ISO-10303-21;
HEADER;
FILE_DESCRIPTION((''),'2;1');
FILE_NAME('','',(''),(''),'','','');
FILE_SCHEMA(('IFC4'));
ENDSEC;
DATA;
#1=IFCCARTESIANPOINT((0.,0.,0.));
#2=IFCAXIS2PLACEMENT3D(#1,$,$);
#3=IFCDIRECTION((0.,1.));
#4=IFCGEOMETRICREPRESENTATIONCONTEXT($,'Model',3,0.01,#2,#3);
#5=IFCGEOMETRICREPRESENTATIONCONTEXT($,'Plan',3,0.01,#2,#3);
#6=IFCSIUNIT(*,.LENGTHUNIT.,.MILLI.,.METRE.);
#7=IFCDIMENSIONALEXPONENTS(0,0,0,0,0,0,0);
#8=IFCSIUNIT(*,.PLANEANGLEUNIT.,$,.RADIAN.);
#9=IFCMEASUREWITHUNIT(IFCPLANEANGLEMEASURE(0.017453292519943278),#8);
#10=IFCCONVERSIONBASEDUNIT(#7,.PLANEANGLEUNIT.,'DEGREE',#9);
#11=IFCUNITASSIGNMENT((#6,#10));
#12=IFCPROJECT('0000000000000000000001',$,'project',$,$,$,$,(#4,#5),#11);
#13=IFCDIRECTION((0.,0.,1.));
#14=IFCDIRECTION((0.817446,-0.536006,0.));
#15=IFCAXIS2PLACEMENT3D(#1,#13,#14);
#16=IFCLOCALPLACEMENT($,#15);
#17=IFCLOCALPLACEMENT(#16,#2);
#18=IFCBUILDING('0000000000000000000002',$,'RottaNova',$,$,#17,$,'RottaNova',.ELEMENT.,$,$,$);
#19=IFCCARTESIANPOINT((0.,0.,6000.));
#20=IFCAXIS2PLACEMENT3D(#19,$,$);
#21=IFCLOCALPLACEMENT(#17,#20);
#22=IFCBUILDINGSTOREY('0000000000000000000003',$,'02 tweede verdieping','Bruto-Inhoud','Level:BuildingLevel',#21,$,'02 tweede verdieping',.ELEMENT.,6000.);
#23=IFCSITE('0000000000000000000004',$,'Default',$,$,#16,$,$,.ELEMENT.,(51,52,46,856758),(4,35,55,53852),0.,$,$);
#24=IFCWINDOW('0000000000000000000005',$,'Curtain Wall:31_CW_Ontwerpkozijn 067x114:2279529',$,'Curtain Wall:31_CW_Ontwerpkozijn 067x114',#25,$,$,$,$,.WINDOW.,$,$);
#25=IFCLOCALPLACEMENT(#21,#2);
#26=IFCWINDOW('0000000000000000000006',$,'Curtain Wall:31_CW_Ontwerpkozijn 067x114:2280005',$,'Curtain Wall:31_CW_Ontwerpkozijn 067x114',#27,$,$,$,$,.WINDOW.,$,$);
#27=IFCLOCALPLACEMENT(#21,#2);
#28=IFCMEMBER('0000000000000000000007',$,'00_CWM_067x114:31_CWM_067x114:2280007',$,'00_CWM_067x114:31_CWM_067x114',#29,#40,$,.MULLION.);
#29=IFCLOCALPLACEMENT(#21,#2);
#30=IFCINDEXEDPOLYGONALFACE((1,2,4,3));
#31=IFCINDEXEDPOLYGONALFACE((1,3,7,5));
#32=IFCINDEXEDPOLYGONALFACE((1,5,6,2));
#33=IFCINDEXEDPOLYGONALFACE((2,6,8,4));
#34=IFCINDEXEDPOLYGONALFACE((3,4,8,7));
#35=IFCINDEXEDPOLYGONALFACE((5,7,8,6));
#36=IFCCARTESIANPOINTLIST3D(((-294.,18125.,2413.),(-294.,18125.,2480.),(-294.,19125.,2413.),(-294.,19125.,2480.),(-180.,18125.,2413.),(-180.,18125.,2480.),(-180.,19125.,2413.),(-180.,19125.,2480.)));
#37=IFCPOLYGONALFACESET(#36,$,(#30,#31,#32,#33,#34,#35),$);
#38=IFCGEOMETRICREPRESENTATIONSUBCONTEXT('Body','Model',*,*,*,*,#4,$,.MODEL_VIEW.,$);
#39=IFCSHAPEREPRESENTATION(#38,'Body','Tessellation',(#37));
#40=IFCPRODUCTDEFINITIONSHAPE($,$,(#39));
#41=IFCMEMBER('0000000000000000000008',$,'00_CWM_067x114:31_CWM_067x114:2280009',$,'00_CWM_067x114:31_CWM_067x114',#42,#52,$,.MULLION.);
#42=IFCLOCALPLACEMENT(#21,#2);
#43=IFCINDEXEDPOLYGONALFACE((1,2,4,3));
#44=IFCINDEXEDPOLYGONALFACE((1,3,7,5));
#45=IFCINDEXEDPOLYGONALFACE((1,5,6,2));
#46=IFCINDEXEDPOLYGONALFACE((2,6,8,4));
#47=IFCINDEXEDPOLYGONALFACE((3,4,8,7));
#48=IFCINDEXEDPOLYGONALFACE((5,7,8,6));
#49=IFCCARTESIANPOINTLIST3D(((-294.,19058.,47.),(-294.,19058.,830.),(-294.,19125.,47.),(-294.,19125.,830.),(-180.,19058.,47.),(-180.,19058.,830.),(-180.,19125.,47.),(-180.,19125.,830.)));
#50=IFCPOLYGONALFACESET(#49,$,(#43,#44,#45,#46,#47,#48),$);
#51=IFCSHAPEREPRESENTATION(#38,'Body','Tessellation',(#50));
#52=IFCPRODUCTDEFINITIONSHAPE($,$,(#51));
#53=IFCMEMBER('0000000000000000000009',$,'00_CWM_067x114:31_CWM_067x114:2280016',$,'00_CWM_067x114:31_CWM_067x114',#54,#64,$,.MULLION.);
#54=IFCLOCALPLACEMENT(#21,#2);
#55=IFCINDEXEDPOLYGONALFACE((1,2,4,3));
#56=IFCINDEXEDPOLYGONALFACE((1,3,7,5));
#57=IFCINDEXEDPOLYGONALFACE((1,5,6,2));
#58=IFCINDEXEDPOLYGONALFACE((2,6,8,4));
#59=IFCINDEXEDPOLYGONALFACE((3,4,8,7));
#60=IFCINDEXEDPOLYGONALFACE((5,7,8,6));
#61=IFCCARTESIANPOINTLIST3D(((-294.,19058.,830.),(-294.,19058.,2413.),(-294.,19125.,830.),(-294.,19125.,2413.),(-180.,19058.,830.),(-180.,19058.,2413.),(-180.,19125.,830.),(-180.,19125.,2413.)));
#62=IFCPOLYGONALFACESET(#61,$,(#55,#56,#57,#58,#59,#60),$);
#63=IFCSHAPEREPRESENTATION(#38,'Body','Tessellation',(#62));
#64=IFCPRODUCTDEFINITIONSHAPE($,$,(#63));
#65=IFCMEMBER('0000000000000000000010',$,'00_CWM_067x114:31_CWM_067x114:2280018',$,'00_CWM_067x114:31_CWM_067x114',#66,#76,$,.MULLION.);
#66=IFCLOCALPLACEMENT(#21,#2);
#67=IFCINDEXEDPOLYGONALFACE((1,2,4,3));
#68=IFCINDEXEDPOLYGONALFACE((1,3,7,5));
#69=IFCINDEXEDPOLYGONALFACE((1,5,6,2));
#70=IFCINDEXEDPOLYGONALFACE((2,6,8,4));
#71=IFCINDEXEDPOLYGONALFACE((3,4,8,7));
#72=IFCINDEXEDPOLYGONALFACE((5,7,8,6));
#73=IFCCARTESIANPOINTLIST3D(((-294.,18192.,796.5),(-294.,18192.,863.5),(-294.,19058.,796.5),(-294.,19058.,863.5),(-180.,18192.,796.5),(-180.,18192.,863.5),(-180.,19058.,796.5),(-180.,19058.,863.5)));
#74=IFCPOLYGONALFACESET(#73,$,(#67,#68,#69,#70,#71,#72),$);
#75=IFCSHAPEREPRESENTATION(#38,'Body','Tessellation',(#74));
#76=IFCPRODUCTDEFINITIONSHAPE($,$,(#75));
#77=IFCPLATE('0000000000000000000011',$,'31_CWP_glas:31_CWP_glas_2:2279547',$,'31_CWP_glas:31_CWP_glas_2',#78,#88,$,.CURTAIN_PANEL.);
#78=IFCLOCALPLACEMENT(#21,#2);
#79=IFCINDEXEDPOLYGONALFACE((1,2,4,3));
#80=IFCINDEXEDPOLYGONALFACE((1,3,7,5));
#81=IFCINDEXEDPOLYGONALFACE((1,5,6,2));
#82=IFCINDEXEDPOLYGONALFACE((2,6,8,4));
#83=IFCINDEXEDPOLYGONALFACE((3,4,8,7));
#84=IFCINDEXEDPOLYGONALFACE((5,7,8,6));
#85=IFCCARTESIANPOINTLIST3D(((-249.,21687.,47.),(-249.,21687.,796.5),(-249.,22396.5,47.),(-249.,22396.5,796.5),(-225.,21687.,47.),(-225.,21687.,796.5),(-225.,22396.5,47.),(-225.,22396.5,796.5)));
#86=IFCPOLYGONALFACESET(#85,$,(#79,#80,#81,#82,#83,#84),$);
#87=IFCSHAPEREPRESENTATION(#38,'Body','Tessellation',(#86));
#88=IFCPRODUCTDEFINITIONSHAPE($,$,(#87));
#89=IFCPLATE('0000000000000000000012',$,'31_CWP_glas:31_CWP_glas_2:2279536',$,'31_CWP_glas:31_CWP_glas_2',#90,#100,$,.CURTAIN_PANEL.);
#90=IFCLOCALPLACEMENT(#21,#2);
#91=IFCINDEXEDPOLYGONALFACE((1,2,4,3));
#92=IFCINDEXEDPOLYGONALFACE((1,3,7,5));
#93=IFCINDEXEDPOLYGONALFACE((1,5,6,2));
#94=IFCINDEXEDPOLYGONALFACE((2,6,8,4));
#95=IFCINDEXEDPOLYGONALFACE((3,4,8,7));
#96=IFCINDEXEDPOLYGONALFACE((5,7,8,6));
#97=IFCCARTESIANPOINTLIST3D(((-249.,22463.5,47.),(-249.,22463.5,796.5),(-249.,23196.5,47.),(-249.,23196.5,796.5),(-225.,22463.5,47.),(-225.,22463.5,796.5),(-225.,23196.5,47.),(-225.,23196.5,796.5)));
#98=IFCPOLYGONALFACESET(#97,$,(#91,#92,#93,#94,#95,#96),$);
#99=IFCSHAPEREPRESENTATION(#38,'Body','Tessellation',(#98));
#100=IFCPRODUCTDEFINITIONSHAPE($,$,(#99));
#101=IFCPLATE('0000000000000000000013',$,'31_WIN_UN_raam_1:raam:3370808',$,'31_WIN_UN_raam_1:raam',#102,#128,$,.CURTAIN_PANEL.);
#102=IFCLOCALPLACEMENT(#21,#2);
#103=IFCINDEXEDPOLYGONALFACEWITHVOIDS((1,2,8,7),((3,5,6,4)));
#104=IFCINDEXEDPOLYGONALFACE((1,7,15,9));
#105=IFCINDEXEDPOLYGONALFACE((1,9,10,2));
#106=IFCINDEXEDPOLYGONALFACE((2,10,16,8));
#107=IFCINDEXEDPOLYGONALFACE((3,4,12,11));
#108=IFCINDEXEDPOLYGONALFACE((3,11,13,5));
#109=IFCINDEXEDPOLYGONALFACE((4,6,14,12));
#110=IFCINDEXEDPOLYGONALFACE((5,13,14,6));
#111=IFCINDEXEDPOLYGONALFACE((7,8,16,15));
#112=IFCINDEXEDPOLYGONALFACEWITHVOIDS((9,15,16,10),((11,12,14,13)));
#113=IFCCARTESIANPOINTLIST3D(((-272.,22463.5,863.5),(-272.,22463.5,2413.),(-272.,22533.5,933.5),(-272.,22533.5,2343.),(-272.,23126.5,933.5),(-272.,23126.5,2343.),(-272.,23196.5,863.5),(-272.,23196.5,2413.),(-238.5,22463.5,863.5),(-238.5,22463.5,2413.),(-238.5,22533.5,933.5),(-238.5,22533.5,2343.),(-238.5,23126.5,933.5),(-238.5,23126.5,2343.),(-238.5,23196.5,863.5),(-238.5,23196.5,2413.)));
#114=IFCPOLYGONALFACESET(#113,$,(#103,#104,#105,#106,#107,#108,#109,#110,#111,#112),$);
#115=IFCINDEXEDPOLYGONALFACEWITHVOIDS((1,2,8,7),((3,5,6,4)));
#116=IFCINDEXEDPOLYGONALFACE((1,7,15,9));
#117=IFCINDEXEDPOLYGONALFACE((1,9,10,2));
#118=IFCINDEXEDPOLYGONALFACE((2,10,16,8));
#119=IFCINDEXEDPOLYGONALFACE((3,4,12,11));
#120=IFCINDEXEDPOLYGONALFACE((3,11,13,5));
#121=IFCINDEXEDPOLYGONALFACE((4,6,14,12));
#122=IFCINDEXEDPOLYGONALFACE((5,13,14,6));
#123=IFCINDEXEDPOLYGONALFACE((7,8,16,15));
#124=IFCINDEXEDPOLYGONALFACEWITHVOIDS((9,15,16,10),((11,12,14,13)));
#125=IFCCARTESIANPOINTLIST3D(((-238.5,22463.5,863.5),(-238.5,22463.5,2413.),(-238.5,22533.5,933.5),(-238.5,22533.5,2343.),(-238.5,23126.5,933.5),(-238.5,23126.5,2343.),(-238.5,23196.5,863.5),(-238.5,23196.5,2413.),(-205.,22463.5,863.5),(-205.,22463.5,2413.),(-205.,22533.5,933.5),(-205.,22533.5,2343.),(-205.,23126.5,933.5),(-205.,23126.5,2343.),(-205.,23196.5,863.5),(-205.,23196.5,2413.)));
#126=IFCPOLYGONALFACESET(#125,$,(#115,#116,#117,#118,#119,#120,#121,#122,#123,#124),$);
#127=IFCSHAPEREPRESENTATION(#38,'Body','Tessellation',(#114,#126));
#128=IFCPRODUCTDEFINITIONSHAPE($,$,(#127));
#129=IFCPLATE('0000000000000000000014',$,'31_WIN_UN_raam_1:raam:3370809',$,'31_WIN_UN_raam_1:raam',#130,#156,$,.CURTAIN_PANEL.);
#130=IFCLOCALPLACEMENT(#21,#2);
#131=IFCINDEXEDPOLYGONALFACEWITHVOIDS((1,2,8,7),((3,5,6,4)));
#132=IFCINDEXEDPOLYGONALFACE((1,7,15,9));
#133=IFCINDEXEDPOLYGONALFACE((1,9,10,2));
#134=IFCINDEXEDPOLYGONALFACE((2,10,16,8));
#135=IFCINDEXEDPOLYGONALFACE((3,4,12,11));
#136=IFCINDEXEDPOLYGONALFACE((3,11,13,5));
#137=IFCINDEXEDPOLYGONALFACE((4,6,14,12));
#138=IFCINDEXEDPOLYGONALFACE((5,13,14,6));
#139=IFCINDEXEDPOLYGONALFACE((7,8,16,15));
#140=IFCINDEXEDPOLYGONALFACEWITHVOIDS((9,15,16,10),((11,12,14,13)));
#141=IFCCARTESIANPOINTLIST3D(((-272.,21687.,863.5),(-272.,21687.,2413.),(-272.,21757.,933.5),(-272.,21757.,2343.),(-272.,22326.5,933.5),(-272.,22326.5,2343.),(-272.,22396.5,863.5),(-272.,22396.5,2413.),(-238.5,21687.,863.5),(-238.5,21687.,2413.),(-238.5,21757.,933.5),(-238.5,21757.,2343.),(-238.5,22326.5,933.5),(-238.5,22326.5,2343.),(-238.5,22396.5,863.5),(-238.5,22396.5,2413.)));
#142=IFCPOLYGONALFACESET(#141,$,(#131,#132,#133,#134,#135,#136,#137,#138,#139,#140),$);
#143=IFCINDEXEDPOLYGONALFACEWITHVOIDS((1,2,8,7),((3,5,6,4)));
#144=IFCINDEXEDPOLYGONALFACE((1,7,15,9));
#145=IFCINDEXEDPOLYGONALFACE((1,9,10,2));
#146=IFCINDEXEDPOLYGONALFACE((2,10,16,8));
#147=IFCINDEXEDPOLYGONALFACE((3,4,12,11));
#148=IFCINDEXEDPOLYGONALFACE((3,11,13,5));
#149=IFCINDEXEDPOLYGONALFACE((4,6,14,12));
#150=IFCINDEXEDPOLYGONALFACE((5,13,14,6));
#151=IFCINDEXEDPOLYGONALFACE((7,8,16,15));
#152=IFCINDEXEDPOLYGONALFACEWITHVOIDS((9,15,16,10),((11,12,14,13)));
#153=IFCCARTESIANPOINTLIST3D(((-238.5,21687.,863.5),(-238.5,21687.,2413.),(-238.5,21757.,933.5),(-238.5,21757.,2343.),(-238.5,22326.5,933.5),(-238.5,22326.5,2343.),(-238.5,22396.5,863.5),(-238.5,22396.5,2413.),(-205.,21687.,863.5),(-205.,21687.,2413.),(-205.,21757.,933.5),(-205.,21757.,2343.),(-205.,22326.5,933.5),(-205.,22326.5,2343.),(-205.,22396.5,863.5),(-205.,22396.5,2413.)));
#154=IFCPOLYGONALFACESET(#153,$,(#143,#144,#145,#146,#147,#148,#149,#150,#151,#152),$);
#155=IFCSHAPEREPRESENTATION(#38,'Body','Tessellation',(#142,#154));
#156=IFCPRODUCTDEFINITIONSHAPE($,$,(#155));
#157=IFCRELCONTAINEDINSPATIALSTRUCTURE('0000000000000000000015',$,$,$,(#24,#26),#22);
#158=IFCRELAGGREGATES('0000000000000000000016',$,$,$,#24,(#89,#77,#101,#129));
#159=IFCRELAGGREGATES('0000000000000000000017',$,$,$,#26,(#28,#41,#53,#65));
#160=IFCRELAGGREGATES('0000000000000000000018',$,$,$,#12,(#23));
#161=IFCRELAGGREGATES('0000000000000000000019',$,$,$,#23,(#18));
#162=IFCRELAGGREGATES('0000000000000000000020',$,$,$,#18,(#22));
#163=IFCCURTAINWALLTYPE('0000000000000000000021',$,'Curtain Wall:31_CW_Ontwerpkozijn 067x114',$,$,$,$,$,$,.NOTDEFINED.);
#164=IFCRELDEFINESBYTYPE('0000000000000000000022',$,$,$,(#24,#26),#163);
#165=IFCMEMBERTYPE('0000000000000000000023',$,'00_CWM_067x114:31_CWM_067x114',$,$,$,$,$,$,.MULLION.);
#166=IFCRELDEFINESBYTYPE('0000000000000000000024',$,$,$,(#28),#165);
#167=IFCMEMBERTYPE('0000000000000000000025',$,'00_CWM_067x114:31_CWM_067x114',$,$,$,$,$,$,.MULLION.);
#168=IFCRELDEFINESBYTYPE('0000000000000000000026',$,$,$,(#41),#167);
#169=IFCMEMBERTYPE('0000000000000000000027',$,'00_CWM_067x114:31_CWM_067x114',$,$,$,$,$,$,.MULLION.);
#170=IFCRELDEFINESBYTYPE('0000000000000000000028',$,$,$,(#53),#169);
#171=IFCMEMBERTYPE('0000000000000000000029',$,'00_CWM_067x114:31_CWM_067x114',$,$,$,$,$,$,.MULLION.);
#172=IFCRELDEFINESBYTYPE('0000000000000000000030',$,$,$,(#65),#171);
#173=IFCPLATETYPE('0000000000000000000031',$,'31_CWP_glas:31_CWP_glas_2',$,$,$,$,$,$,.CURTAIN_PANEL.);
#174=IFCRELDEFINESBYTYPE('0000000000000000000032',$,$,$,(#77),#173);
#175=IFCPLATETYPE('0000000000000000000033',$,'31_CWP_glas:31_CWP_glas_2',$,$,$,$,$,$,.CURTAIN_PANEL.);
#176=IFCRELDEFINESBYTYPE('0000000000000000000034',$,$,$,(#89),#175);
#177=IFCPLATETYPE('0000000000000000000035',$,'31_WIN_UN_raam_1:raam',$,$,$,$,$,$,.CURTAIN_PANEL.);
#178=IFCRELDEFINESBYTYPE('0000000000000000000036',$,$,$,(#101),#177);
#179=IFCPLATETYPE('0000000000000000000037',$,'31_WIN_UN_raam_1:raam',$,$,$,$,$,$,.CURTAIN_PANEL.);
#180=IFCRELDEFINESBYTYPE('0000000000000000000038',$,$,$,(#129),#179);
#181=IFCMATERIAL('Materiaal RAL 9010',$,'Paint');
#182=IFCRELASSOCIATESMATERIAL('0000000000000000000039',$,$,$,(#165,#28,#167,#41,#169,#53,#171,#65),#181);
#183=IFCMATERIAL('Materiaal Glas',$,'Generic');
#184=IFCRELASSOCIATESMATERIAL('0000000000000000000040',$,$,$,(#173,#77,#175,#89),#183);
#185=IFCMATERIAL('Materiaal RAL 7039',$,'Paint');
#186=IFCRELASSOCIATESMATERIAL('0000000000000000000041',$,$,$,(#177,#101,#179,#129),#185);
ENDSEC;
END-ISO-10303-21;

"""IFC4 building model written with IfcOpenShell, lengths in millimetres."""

from ifc_helpers import new_model, entity, si_unit, converted_unit, direction, frame, origin, place, context, subcontext, project, spatial, indexed_curve, outline, extrude, source, transform, mapped, material, type_object, type_shapes, element, aggregate, save


model = new_model("IFC4")

# Units and contexts
model_context = context("Model", 3, precision=0.01, world=origin(), true_north=direction((0.0, 1.0)))
plan_context = context("Plan", 3, precision=0.01, world=origin(), true_north=direction((0.0, 1.0)))
body_context = subcontext(model_context, "Body", "Model", "MODEL_VIEW")
ifc_project = project(units=[si_unit("LENGTHUNIT", "METRE", prefix="MILLI"), converted_unit("PLANEANGLEUNIT", "DEGREE", entity("IfcPlaneAngleMeasure", 0.017453292519943278), si_unit("PLANEANGLEUNIT", "RADIAN"), dimensions=[0, 0, 0, 0, 0, 0, 0])], contexts=[model_context, plan_context])

# Site, building, storey
site_placement = place(None, frame((0.0, 0.0, 0.0), z_axis=(0.0, 0.0, 1.0), x_axis=(0.817446, -0.536006, 0.0)))
site = spatial("IfcSite", under=ifc_project, at=site_placement, Name="Default", CompositionType="ELEMENT", RefLatitude=(51, 52, 46, 856758), RefLongitude=(4, 35, 55, 53852), RefElevation=0.0)
building_placement = place(site_placement, origin())
building = spatial("IfcBuilding", under=site, at=building_placement, Name="RottaNova", LongName="RottaNova", CompositionType="ELEMENT")
storey_placement = place(building_placement, frame((0.0, 0.0, 6000.0)))
storey = spatial("IfcBuildingStorey", under=building, at=storey_placement, Name="02 tweede verdieping", Description="Bruto-Inhoud", ObjectType="Level:BuildingLevel", LongName="02 tweede verdieping", CompositionType="ELEMENT", Elevation=6000.0)

# Windows, members
curtain_wall_type = type_object("IfcCurtainWallType", Name="Curtain Wall:31_CW_Ontwerpkozijn 067x114", PredefinedType="NOTDEFINED")
window_1_placement = place(storey_placement, frame((0.0, 0.0, -6000.0)))
window_1 = element("IfcWindow", 1, at=window_1_placement, inside=storey, type_object=curtain_wall_type, Name="Curtain Wall:31_CW_Ontwerpkozijn 067x114:2279529", ObjectType="Curtain Wall:31_CW_Ontwerpkozijn 067x114", PredefinedType="WINDOW")
ifc_material_1 = material(Name="Materiaal RAL 9010", Category="Paint")
window_2_placement = place(storey_placement, frame((0.0, 0.0, -6000.0)))
window_2 = element("IfcWindow", 2, at=window_2_placement, inside=storey, type_object=curtain_wall_type, Name="Curtain Wall:31_CW_Ontwerpkozijn 067x114:2280005", ObjectType="Curtain Wall:31_CW_Ontwerpkozijn 067x114", PredefinedType="WINDOW")
member_type_1 = type_object("IfcMemberType", Name="00_CWM_067x114:31_CWM_067x114", PredefinedType="MULLION", material=ifc_material_1)
shared_shape_1 = source(origin(), body_context, "Body", "SweptSolid", [
    extrude(outline(indexed_curve([(-33.5, -57.0), (33.5, -57.0), (33.5, 57.0), (-33.5, 57.0), (-33.5, -57.0)], self_intersect=False)), frame((-33.5, -57.0, -1000.0), z_axis=(0.0, 0.0, 1.0), x_axis=(-1.0, 0.0, 0.0)), (0.0, 0.0, 1.0), 1000.0),
])
type_shapes(member_type_1, [shared_shape_1])
member_1_placement = place(window_2_placement, frame((-180.0, 19125.0, 8480.0), z_axis=(0.0, 1.0, 0.0), x_axis=(0.0, 0.0, 1.0)))
member_1 = element("IfcMember", 3, at=member_1_placement, type_object=member_type_1, material=ifc_material_1, Name="00_CWM_067x114:31_CWM_067x114:2280007", ObjectType="00_CWM_067x114:31_CWM_067x114", PredefinedType="MULLION", context=body_context, shape_type="MappedRepresentation", body=[
    mapped(shared_shape_1, transform((0.0, 0.0, 0.0), scale=1.0)),
])
member_type_2 = type_object("IfcMemberType", Name="00_CWM_067x114:31_CWM_067x114", PredefinedType="MULLION", material=ifc_material_1)
shared_shape_2 = source(origin(), body_context, "Body", "SweptSolid", [
    extrude(outline(indexed_curve([(-33.5, -57.0), (33.5, -57.0), (33.5, 57.0), (-33.5, 57.0), (-33.5, -57.0)], self_intersect=False)), frame((-33.5, -57.0, -783.0), z_axis=(0.0, 0.0, 1.0), x_axis=(-1.0, 0.0, 0.0)), (0.0, 0.0, 1.0), 783.0),
])
type_shapes(member_type_2, [shared_shape_2])
member_2_placement = place(window_2_placement, frame((-180.0, 19125.0, 6047.0), z_axis=(0.0, 0.0, -1.0), x_axis=(0.0, 1.0, 0.0)))
member_2 = element("IfcMember", 4, at=member_2_placement, type_object=member_type_2, material=ifc_material_1, Name="00_CWM_067x114:31_CWM_067x114:2280009", ObjectType="00_CWM_067x114:31_CWM_067x114", PredefinedType="MULLION", context=body_context, shape_type="MappedRepresentation", body=[
    mapped(shared_shape_2, transform((0.0, 0.0, 0.0), scale=1.0)),
])
member_type_3 = type_object("IfcMemberType", Name="00_CWM_067x114:31_CWM_067x114", PredefinedType="MULLION", material=ifc_material_1)
shared_shape_3 = source(origin(), body_context, "Body", "SweptSolid", [
    extrude(outline(indexed_curve([(-33.5, -57.0), (33.5, -57.0), (33.5, 57.0), (-33.5, 57.0), (-33.5, -57.0)], self_intersect=False)), frame((-33.5, -57.0, -1583.0), z_axis=(0.0, 0.0, 1.0), x_axis=(-1.0, 0.0, 0.0)), (0.0, 0.0, 1.0), 1583.0),
])
type_shapes(member_type_3, [shared_shape_3])
member_3_placement = place(window_2_placement, frame((-180.0, 19125.0, 6830.0), z_axis=(0.0, 0.0, -1.0), x_axis=(0.0, 1.0, 0.0)))
member_3 = element("IfcMember", 5, at=member_3_placement, type_object=member_type_3, material=ifc_material_1, Name="00_CWM_067x114:31_CWM_067x114:2280016", ObjectType="00_CWM_067x114:31_CWM_067x114", PredefinedType="MULLION", context=body_context, shape_type="MappedRepresentation", body=[
    mapped(shared_shape_3, transform((0.0, 0.0, 0.0), scale=1.0)),
])
member_type_4 = type_object("IfcMemberType", Name="00_CWM_067x114:31_CWM_067x114", PredefinedType="MULLION", material=ifc_material_1)
shared_shape_4 = source(origin(), body_context, "Body", "SweptSolid", [
    extrude(outline(indexed_curve([(-33.5, -57.0), (33.5, -57.0), (33.5, 57.0), (-33.5, 57.0), (-33.5, -57.0)], self_intersect=False)), frame((0.0, -57.0, -866.0), z_axis=(0.0, 0.0, 1.0), x_axis=(-1.0, 0.0, 0.0)), (0.0, 0.0, 1.0), 866.0),
])
type_shapes(member_type_4, [shared_shape_4])
member_4_placement = place(window_2_placement, frame((-180.0, 19058.0, 6830.0), z_axis=(0.0, 1.0, 0.0), x_axis=(0.0, 0.0, 1.0)))
member_4 = element("IfcMember", 6, at=member_4_placement, type_object=member_type_4, material=ifc_material_1, Name="00_CWM_067x114:31_CWM_067x114:2280018", ObjectType="00_CWM_067x114:31_CWM_067x114", PredefinedType="MULLION", context=body_context, shape_type="MappedRepresentation", body=[
    mapped(shared_shape_4, transform((0.0, 0.0, 0.0), scale=1.0)),
])

# Plates
ifc_material_2 = material(Name="Materiaal Glas", Category="Generic")
plate_type_1 = type_object("IfcPlateType", Name="31_CWP_glas:31_CWP_glas_2", PredefinedType="CURTAIN_PANEL", material=ifc_material_2)
shared_shape_5 = source(origin(), body_context, "Body", "SweptSolid", [
    extrude(outline(indexed_curve([(-12.0, -354.8), (12.0, -354.8), (12.0, 354.8), (-12.0, 354.8), (-12.0, -354.8)], self_intersect=False)), frame((0.0, -57.0, 0.0), z_axis=(0.0, 0.0, 1.0), x_axis=(0.0, 1.0, 0.0)), (0.0, 0.0, 1.0), 749.5),
])
type_shapes(plate_type_1, [shared_shape_5])
plate_1_placement = place(window_1_placement, frame((-180.0, 22041.7, 6047.0), z_axis=(0.0, 0.0, 1.0), x_axis=(0.0, -1.0, 0.0)))
plate_1 = element("IfcPlate", 7, at=plate_1_placement, type_object=plate_type_1, material=ifc_material_2, Name="31_CWP_glas:31_CWP_glas_2:2279547", ObjectType="31_CWP_glas:31_CWP_glas_2", PredefinedType="CURTAIN_PANEL", context=body_context, shape_type="MappedRepresentation", body=[
    mapped(shared_shape_5, transform((0.0, 0.0, 0.0), scale=1.0)),
])
plate_type_2 = type_object("IfcPlateType", Name="31_CWP_glas:31_CWP_glas_2", PredefinedType="CURTAIN_PANEL", material=ifc_material_2)
shared_shape_6 = source(origin(), body_context, "Body", "SweptSolid", [
    extrude(outline(indexed_curve([(-12.0, -366.5), (12.0, -366.5), (12.0, 366.5), (-12.0, 366.5), (-12.0, -366.5)], self_intersect=False)), frame((0.0, -57.0, 0.0), z_axis=(0.0, 0.0, 1.0), x_axis=(0.0, 1.0, 0.0)), (0.0, 0.0, 1.0), 749.5),
])
type_shapes(plate_type_2, [shared_shape_6])
plate_2_placement = place(window_1_placement, frame((-180.0, 22830.0, 6047.0), z_axis=(0.0, 0.0, 1.0), x_axis=(0.0, -1.0, 0.0)))
plate_2 = element("IfcPlate", 8, at=plate_2_placement, type_object=plate_type_2, material=ifc_material_2, Name="31_CWP_glas:31_CWP_glas_2:2279536", ObjectType="31_CWP_glas:31_CWP_glas_2", PredefinedType="CURTAIN_PANEL", context=body_context, shape_type="MappedRepresentation", body=[
    mapped(shared_shape_6, transform((0.0, 0.0, 0.0), scale=1.0)),
])
ifc_material_3 = material(Name="Materiaal RAL 7039", Category="Paint")
plate_type_3 = type_object("IfcPlateType", Name="31_WIN_UN_raam_1:raam", PredefinedType="CURTAIN_PANEL", material=ifc_material_3)
shared_shape_7 = source(origin(), body_context, "Body", "SweptSolid", [
    extrude(outline(indexed_curve([(-366.5, -774.7), (366.5, -774.7), (366.5, 774.7), (-366.5, 774.7), (-366.5, -774.7)], self_intersect=False), holes=[indexed_curve([(-296.5, 704.7), (296.5, 704.7), (296.5, -704.8), (-296.5, -704.8), (-296.5, 704.7)], self_intersect=False)]), frame((0.0, -92.0, 774.8), z_axis=(0.0, 1.0, 0.0), x_axis=(1.0, 0.0, 0.0)), (0.0, 0.0, 1.0), 33.5),
    extrude(outline(indexed_curve([(-366.5, -774.7), (366.5, -774.7), (366.5, 774.7), (-366.5, 774.7), (-366.5, -774.7)], self_intersect=False), holes=[indexed_curve([(-296.5, 704.7), (296.5, 704.7), (296.5, -704.8), (-296.5, -704.8), (-296.5, 704.7)], self_intersect=False)]), frame((0.0, -58.5, 774.8), z_axis=(0.0, 1.0, 0.0), x_axis=(1.0, 0.0, 0.0)), (0.0, 0.0, 1.0), 33.5),
])
type_shapes(plate_type_3, [shared_shape_7])
plate_3_placement = place(window_1_placement, frame((-180.0, 22830.0, 6863.5), z_axis=(0.0, 0.0, 1.0), x_axis=(0.0, -1.0, 0.0)))
plate_3 = element("IfcPlate", 9, at=plate_3_placement, type_object=plate_type_3, material=ifc_material_3, Name="31_WIN_UN_raam_1:raam:3370808", ObjectType="31_WIN_UN_raam_1:raam", PredefinedType="CURTAIN_PANEL", context=body_context, shape_type="MappedRepresentation", body=[
    mapped(shared_shape_7, transform((0.0, 0.0, 0.0), scale=1.0)),
])
plate_type_4 = type_object("IfcPlateType", Name="31_WIN_UN_raam_1:raam", PredefinedType="CURTAIN_PANEL", material=ifc_material_3)
shared_shape_8 = source(origin(), body_context, "Body", "SweptSolid", [
    extrude(outline(indexed_curve([(-354.7, -774.7), (354.7, -774.7), (354.7, 774.7), (-354.7, 774.7), (-354.7, -774.7)], self_intersect=False), holes=[indexed_curve([(-284.7, 704.7), (284.7, 704.7), (284.7, -704.8), (-284.7, -704.8), (-284.7, 704.7)], self_intersect=False)]), frame((0.0, -92.0, 774.8), z_axis=(0.0, 1.0, 0.0), x_axis=(1.0, 0.0, 0.0)), (0.0, 0.0, 1.0), 33.5),
    extrude(outline(indexed_curve([(-354.7, -774.7), (354.7, -774.7), (354.7, 774.7), (-354.7, 774.7), (-354.7, -774.7)], self_intersect=False), holes=[indexed_curve([(-284.7, 704.7), (284.7, 704.7), (284.7, -704.8), (-284.7, -704.8), (-284.7, 704.7)], self_intersect=False)]), frame((0.0, -58.5, 774.8), z_axis=(0.0, 1.0, 0.0), x_axis=(1.0, 0.0, 0.0)), (0.0, 0.0, 1.0), 33.5),
])
type_shapes(plate_type_4, [shared_shape_8])
plate_4_placement = place(window_1_placement, frame((-180.0, 22041.7, 6863.5), z_axis=(0.0, 0.0, 1.0), x_axis=(0.0, -1.0, 0.0)))
plate_4 = element("IfcPlate", 10, at=plate_4_placement, type_object=plate_type_4, material=ifc_material_3, Name="31_WIN_UN_raam_1:raam:3370809", ObjectType="31_WIN_UN_raam_1:raam", PredefinedType="CURTAIN_PANEL", context=body_context, shape_type="MappedRepresentation", body=[
    mapped(shared_shape_8, transform((0.0, 0.0, 0.0), scale=1.0)),
])
aggregate(window_1, [plate_2, plate_1, plate_3, plate_4])
aggregate(window_2, [member_1, member_2, member_3, member_4])

save(model, "model.ifc")
